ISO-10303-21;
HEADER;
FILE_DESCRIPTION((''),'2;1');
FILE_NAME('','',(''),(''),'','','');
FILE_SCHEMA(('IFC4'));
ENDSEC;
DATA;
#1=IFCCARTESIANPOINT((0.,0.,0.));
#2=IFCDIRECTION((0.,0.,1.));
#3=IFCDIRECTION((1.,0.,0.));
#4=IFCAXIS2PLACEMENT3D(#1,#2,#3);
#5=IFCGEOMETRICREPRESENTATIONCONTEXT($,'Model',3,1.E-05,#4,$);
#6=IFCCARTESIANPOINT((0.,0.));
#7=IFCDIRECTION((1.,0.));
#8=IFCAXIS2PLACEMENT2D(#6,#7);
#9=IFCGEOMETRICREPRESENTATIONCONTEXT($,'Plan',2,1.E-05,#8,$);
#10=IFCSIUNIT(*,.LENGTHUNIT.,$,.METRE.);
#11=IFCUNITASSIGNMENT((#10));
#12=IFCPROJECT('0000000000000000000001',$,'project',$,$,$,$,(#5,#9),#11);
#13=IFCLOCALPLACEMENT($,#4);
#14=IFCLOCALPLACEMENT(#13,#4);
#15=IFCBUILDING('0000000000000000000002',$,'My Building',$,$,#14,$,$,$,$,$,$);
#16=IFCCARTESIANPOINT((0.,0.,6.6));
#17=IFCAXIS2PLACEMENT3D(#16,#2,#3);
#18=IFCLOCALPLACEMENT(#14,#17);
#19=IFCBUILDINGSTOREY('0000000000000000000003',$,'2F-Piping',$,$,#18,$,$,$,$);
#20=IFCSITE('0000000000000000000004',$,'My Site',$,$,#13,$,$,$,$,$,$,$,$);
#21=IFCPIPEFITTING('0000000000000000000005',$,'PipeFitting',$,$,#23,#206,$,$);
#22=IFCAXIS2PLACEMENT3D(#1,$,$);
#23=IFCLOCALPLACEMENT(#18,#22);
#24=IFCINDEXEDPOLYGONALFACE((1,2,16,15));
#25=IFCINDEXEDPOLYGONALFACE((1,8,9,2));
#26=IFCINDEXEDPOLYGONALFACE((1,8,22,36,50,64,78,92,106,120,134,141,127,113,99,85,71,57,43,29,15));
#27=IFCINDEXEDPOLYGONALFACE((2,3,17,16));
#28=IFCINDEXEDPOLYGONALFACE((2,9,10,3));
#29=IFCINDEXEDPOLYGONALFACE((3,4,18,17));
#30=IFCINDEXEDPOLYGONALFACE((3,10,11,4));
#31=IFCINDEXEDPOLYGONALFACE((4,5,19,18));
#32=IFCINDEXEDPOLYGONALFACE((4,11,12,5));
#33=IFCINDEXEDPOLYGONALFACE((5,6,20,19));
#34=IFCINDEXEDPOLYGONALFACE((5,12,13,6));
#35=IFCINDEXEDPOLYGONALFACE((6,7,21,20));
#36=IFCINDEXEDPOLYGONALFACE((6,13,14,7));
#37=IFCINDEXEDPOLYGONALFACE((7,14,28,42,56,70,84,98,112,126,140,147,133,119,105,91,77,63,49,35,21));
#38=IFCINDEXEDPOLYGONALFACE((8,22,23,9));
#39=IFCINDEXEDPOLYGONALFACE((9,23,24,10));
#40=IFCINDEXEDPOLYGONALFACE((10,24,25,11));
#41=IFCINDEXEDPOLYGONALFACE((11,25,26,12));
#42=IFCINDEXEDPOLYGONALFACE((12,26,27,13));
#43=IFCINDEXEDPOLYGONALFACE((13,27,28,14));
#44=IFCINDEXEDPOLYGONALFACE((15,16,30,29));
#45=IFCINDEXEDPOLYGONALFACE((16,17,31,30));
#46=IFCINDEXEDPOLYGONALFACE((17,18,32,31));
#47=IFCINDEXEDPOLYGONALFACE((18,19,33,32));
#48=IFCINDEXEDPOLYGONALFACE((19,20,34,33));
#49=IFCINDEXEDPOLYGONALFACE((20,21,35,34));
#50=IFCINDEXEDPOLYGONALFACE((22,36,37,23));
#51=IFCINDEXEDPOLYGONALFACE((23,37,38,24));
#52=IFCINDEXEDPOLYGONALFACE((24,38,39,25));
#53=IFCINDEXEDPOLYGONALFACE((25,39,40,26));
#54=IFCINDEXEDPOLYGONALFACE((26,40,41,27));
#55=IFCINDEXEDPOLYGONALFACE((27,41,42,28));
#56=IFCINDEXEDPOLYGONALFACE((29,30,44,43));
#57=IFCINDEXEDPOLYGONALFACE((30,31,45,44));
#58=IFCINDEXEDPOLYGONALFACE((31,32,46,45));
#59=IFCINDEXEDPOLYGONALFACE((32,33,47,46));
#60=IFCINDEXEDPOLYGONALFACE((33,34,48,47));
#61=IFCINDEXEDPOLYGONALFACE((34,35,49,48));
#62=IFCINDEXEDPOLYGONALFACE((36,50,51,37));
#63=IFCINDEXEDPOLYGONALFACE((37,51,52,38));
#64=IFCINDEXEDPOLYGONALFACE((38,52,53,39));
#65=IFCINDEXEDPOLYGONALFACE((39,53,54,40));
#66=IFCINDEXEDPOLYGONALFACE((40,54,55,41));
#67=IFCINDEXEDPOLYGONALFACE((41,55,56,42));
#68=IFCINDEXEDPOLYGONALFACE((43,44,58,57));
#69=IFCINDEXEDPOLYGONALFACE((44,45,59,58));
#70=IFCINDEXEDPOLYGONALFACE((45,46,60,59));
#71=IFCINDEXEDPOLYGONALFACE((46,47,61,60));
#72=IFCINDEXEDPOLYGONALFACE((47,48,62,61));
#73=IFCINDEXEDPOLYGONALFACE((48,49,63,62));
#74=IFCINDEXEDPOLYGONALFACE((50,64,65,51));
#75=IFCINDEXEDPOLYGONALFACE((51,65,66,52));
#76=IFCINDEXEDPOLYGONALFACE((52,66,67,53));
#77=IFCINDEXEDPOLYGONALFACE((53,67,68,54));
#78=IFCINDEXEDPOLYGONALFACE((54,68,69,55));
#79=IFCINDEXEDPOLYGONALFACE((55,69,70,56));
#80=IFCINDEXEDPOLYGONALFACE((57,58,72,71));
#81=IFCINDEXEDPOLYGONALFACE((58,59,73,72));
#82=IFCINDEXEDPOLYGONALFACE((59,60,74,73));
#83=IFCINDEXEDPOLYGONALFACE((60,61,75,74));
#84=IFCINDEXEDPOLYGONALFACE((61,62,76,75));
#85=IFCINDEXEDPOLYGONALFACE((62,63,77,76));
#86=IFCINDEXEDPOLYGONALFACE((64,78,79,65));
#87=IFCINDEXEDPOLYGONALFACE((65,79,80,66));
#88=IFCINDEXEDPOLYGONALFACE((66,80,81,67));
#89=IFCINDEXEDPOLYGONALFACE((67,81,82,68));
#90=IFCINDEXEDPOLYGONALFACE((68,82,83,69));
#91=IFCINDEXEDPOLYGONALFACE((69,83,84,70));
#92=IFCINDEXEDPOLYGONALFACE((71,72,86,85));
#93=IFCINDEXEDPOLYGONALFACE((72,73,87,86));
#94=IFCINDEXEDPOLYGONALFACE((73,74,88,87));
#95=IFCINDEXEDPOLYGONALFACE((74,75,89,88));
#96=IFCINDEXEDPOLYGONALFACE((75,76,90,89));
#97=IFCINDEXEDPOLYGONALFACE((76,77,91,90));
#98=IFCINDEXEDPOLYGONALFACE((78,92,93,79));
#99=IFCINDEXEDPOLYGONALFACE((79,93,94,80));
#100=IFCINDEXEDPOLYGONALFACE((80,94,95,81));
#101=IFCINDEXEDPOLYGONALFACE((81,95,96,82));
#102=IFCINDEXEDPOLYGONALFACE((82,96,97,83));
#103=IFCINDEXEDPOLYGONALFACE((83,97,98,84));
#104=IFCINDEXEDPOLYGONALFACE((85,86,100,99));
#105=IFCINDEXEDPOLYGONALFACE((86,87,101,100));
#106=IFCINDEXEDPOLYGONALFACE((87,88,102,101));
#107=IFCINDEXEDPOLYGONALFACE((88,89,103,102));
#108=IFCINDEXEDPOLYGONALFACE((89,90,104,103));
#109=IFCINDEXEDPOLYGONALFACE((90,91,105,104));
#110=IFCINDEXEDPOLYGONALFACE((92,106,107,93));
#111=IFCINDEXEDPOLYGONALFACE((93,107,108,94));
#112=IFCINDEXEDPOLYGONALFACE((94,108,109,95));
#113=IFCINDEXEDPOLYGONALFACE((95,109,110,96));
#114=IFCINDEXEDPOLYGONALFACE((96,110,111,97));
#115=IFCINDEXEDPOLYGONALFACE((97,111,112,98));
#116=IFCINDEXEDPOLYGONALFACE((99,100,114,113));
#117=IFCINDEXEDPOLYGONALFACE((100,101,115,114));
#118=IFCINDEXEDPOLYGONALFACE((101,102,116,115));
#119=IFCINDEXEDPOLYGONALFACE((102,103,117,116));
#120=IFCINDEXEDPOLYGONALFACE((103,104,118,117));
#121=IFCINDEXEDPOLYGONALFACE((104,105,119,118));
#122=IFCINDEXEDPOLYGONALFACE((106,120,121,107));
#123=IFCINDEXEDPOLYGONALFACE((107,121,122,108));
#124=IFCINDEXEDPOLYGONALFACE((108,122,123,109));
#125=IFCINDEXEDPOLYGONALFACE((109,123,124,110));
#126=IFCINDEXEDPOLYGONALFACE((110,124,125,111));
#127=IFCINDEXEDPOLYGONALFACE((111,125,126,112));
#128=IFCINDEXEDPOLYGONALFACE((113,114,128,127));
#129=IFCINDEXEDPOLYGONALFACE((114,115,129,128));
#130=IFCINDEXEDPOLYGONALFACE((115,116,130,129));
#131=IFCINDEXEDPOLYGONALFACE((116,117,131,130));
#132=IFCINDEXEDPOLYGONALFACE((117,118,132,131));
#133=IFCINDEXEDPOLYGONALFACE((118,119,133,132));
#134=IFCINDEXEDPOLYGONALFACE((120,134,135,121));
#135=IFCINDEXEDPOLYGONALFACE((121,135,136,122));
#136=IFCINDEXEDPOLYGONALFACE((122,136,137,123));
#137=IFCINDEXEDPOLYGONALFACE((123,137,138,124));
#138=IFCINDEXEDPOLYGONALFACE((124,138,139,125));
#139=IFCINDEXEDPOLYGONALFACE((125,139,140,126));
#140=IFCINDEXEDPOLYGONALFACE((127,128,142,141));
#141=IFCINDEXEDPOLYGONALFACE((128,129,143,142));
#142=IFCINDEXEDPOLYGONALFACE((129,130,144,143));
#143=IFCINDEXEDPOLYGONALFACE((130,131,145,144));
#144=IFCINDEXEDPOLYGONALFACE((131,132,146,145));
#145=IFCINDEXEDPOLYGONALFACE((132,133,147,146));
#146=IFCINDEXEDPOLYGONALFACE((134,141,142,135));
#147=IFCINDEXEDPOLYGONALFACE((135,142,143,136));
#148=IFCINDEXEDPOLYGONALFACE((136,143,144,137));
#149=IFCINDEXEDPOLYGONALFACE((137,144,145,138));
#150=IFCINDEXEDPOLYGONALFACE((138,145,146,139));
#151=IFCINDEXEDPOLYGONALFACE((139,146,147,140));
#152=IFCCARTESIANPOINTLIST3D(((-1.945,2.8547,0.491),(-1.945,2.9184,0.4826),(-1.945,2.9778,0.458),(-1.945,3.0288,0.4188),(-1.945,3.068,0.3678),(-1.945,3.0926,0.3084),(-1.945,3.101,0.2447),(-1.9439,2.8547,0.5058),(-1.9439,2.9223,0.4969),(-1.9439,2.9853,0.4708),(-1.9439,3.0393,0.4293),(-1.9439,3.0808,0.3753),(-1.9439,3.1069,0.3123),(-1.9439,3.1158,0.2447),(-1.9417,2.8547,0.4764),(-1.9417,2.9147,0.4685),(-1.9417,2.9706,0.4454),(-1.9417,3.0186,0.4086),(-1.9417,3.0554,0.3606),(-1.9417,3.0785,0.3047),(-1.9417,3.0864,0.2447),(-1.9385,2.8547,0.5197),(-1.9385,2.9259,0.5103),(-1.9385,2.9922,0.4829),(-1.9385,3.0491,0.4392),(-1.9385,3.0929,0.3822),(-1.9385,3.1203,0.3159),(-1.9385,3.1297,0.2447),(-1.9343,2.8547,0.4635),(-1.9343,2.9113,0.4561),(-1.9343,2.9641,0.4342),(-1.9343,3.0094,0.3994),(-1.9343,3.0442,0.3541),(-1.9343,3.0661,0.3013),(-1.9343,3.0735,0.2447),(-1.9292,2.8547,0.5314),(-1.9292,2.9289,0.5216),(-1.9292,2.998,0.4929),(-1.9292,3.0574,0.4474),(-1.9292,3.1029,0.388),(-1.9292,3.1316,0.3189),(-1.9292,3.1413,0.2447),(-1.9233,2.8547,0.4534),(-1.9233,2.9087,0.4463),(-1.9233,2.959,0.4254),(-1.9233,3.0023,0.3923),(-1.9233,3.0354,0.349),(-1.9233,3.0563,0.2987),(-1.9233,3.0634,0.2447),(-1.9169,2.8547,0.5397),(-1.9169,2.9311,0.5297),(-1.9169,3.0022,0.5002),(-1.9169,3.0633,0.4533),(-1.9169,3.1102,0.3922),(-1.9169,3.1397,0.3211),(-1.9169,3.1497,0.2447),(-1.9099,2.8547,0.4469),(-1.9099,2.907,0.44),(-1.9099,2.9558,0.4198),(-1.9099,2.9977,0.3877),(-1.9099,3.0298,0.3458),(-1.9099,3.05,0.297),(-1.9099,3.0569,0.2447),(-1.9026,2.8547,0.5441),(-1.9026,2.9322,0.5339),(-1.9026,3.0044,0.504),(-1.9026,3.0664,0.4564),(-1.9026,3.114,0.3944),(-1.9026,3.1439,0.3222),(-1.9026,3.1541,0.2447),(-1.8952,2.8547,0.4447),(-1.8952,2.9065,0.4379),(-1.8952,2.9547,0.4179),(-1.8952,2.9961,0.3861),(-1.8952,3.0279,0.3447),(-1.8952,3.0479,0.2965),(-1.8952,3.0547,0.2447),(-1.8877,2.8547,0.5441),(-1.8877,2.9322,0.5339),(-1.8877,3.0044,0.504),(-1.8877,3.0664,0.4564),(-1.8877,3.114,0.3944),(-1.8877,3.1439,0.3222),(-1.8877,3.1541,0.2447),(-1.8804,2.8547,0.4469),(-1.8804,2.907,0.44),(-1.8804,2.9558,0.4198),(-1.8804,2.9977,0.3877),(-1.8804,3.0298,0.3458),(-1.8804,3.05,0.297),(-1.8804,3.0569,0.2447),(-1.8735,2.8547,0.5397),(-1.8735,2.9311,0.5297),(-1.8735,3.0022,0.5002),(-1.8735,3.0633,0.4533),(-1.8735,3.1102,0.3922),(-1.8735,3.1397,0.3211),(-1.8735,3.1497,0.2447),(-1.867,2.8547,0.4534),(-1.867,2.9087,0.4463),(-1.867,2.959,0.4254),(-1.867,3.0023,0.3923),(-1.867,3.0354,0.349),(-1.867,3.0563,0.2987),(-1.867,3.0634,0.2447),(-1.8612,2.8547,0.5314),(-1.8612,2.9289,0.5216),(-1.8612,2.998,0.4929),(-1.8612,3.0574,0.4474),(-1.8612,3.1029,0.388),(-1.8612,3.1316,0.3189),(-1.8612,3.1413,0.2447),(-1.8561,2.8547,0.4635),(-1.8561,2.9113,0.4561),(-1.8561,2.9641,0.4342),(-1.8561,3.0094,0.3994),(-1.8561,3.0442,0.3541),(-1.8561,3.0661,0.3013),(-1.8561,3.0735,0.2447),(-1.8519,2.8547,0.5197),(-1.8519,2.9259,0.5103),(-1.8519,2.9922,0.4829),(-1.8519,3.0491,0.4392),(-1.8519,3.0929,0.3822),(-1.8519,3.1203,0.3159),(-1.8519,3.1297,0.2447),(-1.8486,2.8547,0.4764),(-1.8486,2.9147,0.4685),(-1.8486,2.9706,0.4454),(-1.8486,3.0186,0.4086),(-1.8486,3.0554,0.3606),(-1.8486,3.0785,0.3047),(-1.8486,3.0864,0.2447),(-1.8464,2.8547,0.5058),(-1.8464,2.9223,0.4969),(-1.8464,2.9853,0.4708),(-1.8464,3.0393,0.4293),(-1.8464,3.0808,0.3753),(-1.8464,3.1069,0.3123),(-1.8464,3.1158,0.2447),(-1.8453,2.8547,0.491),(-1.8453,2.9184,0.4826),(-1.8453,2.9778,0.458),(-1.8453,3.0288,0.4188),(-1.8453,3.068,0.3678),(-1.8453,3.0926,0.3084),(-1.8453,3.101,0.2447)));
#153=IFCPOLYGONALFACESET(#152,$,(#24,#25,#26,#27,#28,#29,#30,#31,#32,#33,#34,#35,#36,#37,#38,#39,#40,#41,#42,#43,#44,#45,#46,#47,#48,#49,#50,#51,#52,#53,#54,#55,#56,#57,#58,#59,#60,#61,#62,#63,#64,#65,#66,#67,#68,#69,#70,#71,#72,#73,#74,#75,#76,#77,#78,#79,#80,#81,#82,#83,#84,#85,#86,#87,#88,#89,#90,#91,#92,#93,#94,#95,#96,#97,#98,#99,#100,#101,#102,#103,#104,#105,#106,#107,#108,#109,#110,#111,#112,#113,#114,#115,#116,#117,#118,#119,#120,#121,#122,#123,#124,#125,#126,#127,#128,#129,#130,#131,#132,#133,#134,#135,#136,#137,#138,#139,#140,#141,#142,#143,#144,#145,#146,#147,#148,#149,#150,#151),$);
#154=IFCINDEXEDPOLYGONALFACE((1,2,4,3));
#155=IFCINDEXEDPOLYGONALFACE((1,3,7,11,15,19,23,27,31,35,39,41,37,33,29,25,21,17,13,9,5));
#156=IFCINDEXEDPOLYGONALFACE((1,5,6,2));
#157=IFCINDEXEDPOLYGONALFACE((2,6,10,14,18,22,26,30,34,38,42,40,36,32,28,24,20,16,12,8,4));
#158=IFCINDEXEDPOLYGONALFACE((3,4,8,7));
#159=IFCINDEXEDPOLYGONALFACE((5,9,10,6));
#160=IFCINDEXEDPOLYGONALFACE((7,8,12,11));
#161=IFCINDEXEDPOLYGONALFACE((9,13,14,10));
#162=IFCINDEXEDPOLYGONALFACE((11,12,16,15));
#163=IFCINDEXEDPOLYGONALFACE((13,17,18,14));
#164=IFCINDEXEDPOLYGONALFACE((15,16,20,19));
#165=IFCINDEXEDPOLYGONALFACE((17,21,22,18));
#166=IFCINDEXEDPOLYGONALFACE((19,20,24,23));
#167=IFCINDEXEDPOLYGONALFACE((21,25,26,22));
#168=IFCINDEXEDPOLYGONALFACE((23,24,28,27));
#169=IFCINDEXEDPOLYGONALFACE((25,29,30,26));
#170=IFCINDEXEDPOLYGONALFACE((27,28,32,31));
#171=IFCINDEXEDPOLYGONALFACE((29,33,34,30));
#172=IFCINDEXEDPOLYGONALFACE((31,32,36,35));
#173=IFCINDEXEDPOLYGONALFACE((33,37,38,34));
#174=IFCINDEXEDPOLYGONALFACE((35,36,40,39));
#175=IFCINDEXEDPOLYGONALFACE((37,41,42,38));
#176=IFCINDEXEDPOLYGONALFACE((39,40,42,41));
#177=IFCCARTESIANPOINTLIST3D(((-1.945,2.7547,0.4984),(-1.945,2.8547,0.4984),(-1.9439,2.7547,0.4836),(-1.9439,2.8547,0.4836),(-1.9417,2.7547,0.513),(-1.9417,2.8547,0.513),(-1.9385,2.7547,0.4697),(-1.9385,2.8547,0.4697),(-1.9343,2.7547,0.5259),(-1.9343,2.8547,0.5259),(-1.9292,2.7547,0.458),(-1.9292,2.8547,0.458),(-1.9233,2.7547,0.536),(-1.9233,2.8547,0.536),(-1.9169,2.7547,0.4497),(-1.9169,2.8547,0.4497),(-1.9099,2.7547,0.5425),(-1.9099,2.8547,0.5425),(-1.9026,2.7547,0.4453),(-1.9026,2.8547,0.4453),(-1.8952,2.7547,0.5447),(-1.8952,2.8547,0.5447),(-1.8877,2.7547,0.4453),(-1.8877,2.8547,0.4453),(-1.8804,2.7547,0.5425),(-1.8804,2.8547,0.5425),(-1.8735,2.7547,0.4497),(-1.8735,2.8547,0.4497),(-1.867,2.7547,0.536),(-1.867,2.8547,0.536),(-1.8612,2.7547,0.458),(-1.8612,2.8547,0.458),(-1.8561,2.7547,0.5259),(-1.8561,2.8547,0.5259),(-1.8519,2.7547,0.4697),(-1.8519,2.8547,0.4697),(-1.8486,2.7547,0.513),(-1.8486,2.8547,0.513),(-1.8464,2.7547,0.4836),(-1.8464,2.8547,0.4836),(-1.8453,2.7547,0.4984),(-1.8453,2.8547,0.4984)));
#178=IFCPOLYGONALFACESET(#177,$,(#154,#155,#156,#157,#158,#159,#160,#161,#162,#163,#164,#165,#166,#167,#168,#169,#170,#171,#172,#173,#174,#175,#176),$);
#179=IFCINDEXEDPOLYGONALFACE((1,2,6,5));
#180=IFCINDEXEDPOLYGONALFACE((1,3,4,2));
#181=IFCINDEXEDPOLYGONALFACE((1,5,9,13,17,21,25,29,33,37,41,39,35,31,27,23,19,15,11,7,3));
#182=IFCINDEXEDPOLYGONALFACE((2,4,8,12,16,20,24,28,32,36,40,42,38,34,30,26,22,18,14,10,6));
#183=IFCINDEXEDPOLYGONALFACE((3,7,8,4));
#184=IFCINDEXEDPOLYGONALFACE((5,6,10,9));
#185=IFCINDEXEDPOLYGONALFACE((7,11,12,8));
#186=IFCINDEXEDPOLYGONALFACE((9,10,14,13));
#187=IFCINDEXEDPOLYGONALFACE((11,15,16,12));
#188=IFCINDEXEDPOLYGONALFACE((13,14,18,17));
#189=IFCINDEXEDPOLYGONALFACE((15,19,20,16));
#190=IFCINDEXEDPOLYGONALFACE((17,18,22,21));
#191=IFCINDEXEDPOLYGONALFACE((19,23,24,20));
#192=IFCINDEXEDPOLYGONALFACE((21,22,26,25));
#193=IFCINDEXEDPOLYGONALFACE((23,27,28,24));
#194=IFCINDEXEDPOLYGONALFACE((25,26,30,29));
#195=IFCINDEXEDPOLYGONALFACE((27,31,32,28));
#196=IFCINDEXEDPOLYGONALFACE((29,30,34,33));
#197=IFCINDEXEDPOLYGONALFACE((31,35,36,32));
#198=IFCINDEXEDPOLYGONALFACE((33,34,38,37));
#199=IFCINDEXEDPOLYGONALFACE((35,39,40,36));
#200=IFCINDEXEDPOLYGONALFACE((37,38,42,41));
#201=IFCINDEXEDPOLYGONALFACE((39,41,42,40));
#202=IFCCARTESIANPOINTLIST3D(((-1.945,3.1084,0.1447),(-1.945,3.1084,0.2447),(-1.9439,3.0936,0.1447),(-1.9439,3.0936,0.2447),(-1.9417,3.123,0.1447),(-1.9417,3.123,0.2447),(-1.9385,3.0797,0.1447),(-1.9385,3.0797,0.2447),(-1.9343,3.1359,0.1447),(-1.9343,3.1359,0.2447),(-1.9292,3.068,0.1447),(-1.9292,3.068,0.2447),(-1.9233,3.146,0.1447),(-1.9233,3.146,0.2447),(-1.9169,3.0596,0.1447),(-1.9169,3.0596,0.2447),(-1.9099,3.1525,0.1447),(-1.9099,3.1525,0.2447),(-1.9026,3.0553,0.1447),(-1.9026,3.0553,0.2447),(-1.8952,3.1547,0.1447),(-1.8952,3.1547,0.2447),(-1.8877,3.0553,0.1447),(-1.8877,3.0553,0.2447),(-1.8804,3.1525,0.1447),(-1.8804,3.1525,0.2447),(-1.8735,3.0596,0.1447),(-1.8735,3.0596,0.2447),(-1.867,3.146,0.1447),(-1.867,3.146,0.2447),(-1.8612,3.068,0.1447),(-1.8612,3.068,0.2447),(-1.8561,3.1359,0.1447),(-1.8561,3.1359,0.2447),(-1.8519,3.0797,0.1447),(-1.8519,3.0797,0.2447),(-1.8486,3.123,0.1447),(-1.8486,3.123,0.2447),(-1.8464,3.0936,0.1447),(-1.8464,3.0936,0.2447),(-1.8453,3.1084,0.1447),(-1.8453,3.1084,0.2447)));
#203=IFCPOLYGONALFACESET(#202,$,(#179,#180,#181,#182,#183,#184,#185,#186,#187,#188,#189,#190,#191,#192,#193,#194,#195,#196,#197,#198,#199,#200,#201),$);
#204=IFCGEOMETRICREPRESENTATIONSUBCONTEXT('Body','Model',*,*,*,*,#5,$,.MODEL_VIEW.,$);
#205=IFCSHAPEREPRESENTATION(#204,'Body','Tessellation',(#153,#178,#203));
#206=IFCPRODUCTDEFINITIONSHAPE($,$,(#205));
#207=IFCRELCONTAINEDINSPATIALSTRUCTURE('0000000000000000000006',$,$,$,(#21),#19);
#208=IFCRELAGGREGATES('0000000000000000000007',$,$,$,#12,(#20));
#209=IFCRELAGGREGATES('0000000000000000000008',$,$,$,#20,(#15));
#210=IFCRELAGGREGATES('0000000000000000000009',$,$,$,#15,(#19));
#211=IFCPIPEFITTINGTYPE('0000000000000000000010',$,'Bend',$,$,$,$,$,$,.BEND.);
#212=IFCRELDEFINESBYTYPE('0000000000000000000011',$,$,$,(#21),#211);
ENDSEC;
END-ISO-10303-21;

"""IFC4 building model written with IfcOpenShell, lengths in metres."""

from ifc_helpers import new_model, entity, si_unit, frame, origin_with_axes, origin_2d_with_axis, place, context, subcontext, project, spatial, circle, extrude, source, transform, mapped, type_object, type_shapes, element, save


model = new_model("IFC4")

# Units and contexts
model_context = context("Model", 3, precision=1e-05, world=origin_with_axes())
plan_context = context("Plan", 2, precision=1e-05, world=origin_2d_with_axis())
body_context = subcontext(model_context, "Body", "Model", "MODEL_VIEW")
ifc_project = project(units=[si_unit("LENGTHUNIT", "METRE")], contexts=[model_context, plan_context])

# Site, building, storey
site_placement = place(None, origin_with_axes())
site = spatial("IfcSite", under=ifc_project, at=site_placement, Name="My Site")
building_placement = place(site_placement, origin_with_axes())
building = spatial("IfcBuilding", under=site, at=building_placement, Name="My Building")
storey_placement = place(building_placement, frame((0.0, 0.0, 6.6), z_axis=(0.0, 0.0, 1.0), x_axis=(1.0, 0.0, 0.0)))
storey = spatial("IfcBuildingStorey", under=building, at=storey_placement, Name="2F-Piping")

# Pipe fitting
pipe_fitting_type = type_object("IfcPipeFittingType", Name="Bend", PredefinedType="BEND")
shared_shape = source(origin_with_axes(), body_context, "Body", "SolidModel", [
    entity("IfcSweptDiskSolid", entity("IfcIndexedPolyCurve", entity("IfcCartesianPointList3D", [[0.0, 0.0, -0.1], [-0.0732, 0.0, -0.2768], [-0.25, 0.0, -0.35]]), [entity("IfcArcIndex", [1, 2, 3])]), 0.05),
    extrude(circle(Radius=0.05), origin_with_axes(), (0.0, 0.0, -1.0), 0.1),
    extrude(circle(Radius=0.05), frame((-0.25, 0.0, -0.35), z_axis=(-1.0, 0.0, 0.0), x_axis=(0.0, 0.0, -1.0)), (0.0, 0.0, 1.0), 0.1),
])
type_shapes(pipe_fitting_type, [shared_shape])
for number, where, z_axis, x_axis, name in (
    (1, (-1.8952, 2.7547, 0.4947), (0.0, -1.0, 0.0), (0.0, 0.0, 1.0), "PipeFitting"),
):
    element("IfcPipeFitting", number, at=place(storey_placement, frame(where, z_axis=z_axis, x_axis=x_axis)), inside=storey, type_object=pipe_fitting_type, Name=name, context=body_context, shape_type="MappedRepresentation", body=[
        mapped(shared_shape, transform((0.0, 0.0, 0.0), x_axis=(1.0, 0.0, 0.0), y_axis=(0.0, 1.0, 0.0), z_axis=(0.0, 0.0, 1.0), scale=1.0)),
    ])

save(model, "model.ifc")
